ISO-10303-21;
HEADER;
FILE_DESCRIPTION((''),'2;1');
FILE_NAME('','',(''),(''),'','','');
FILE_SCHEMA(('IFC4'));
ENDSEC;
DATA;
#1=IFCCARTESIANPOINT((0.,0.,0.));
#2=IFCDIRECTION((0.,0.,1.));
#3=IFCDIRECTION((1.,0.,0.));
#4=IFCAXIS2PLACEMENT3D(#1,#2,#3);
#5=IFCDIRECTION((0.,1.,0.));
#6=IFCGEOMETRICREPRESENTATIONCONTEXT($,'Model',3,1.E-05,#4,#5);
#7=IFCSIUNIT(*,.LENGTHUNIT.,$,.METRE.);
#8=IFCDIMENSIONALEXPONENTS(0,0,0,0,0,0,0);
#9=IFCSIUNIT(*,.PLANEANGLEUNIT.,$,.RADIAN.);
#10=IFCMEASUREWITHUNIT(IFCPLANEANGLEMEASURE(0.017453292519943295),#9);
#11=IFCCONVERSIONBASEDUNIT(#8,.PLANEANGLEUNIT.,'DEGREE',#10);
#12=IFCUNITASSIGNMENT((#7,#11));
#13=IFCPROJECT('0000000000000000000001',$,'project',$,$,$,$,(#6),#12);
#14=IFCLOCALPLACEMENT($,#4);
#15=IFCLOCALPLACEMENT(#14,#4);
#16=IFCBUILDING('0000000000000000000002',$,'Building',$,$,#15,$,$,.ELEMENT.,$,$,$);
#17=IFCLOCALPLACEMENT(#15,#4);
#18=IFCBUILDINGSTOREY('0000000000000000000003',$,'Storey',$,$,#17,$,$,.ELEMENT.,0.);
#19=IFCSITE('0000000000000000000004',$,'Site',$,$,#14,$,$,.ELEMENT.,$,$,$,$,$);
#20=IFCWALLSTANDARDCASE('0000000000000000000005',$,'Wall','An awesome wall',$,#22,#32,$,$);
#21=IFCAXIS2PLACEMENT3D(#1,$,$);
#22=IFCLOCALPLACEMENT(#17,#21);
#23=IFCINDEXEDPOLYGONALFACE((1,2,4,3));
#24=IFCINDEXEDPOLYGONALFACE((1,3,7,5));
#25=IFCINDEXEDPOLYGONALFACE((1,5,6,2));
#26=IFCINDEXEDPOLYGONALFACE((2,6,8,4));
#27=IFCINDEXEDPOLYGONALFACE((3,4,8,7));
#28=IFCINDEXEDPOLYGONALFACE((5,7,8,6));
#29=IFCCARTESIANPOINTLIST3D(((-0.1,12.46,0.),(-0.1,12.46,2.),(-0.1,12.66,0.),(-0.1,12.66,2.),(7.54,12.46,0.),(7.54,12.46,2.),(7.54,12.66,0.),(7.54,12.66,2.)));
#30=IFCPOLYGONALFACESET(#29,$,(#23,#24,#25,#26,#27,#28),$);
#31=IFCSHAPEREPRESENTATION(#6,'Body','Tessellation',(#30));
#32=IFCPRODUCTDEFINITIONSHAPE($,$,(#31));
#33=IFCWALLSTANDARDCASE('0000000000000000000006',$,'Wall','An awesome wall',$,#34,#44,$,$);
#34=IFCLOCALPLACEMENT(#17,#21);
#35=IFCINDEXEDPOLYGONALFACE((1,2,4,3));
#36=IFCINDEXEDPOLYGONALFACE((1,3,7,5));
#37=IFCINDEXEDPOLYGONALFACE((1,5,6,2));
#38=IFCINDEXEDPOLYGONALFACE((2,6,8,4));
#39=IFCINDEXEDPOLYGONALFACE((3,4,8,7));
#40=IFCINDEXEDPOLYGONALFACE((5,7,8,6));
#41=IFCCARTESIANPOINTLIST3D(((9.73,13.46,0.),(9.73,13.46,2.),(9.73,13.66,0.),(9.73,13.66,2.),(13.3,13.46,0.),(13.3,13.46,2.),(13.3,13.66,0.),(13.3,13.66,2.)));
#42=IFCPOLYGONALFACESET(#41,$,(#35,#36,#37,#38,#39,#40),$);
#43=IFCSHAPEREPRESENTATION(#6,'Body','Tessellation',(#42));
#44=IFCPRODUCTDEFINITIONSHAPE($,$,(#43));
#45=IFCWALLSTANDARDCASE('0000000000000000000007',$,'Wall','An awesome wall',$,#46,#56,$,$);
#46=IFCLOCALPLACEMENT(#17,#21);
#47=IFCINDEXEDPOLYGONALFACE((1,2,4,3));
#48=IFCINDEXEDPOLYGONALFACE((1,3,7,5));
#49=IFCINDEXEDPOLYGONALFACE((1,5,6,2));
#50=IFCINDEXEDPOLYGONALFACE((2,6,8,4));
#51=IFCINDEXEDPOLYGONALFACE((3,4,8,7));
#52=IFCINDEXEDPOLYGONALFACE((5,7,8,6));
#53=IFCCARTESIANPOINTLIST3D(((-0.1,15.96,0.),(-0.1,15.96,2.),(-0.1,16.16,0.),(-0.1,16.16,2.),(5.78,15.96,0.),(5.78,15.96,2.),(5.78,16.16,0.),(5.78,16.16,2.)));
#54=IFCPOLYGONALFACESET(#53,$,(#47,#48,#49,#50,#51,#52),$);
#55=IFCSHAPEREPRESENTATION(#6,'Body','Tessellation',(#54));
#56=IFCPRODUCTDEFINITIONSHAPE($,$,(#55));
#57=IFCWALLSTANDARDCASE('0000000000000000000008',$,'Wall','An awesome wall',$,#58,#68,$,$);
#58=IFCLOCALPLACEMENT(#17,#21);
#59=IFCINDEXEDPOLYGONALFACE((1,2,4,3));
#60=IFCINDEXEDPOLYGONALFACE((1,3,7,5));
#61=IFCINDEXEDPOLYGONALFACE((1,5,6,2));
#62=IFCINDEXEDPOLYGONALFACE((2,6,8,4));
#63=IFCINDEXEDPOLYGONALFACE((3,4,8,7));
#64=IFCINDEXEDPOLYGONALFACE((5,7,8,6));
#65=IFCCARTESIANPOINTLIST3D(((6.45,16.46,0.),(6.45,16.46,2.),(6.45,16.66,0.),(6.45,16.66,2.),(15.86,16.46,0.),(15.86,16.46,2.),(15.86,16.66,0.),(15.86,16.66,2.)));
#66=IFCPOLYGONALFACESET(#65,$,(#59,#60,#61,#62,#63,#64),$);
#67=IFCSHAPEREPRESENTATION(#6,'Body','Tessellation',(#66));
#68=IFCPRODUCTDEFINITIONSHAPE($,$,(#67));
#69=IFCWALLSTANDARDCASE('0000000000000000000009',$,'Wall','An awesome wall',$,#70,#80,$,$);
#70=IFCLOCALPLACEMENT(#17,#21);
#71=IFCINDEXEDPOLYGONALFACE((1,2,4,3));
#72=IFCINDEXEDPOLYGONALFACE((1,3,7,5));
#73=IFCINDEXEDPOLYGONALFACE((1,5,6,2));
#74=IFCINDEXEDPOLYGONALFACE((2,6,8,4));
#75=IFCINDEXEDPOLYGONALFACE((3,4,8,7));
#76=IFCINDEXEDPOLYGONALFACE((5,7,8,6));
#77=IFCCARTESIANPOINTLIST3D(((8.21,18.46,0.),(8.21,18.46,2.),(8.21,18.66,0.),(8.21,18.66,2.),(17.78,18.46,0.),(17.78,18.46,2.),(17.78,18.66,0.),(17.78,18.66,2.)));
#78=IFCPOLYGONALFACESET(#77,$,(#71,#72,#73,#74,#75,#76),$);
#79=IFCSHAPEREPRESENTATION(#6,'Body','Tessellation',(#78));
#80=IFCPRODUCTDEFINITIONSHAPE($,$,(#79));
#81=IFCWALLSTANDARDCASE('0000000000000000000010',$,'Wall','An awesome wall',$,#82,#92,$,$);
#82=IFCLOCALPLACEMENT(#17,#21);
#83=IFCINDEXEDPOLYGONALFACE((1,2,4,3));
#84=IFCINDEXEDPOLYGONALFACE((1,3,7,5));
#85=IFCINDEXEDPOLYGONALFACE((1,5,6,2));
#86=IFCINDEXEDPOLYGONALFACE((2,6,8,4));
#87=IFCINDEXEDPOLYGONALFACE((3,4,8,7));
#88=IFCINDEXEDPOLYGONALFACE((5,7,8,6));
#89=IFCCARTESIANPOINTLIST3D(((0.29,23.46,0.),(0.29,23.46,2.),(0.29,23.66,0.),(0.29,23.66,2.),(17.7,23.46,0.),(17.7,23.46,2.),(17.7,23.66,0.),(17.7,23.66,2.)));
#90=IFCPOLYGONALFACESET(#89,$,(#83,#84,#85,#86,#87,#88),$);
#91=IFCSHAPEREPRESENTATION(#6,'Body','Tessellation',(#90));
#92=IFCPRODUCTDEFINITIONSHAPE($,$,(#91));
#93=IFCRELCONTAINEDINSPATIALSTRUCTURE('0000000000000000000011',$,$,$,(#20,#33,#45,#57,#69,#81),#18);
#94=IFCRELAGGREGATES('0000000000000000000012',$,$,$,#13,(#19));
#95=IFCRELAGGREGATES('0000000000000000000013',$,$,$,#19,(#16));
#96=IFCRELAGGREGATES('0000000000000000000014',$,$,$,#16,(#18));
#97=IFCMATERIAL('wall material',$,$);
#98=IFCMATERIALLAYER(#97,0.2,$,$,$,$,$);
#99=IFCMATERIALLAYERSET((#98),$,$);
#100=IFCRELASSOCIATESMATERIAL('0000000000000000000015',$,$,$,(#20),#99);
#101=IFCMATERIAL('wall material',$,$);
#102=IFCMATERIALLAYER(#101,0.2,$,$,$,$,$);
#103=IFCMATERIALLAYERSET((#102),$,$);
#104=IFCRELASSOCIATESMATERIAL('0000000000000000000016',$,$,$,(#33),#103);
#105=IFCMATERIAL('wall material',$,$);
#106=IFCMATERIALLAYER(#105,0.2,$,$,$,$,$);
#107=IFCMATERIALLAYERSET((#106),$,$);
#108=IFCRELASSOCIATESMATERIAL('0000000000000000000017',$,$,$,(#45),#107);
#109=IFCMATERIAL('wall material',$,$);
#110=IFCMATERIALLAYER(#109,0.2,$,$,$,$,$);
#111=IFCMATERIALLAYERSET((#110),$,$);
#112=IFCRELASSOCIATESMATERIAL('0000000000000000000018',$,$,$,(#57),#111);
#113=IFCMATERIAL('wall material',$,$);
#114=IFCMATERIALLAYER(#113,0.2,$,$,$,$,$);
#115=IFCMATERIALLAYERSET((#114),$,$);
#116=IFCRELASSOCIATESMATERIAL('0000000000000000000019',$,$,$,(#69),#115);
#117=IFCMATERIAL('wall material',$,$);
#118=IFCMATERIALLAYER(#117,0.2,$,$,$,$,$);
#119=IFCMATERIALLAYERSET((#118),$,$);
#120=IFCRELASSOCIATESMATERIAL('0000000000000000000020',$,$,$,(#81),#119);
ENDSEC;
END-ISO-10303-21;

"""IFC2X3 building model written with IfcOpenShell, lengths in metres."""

from ifc_helpers import new_model, entity, si_unit, converted_unit, direction, frame, origin_with_axes, place, context, project, spatial, polyline, outline, extrude, material, layer, layer_set, layer_usage, element, save


model = new_model("IFC2X3")

# Units and contexts
model_context = context("Model", 3, precision=1e-05, world=origin_with_axes(), true_north=direction((0.0, 1.0, 0.0)))
ifc_project = project(units=[si_unit("LENGTHUNIT", "METRE"), converted_unit("PLANEANGLEUNIT", "DEGREE", entity("IfcPlaneAngleMeasure", 0.017453292519943295), si_unit("PLANEANGLEUNIT", "RADIAN"), dimensions=[0, 0, 0, 0, 0, 0, 0])], contexts=[model_context])

# Site, building, storey
site_placement = place(None, origin_with_axes())
site = spatial("IfcSite", under=ifc_project, at=site_placement, Name="Site", CompositionType="ELEMENT")
building_placement = place(site_placement, origin_with_axes())
building = spatial("IfcBuilding", under=site, at=building_placement, Name="Building", CompositionType="ELEMENT")
storey_placement = place(building_placement, origin_with_axes())
storey = spatial("IfcBuildingStorey", under=building, at=storey_placement, Name="Storey", CompositionType="ELEMENT", Elevation=0.0)

# Walls
ifc_material_1 = material(Name="wall material")
ifc_layer_1 = layer(ifc_material_1, 0.2)
ifc_layer_set_1 = layer_set([ifc_layer_1])
ifc_layer_usage_1 = layer_usage(ifc_layer_set_1, "AXIS2", "POSITIVE", -0.1)
wall_1_placement = place(storey_placement, origin_with_axes())
element("IfcWallStandardCase", 1, at=wall_1_placement, inside=storey, material=ifc_layer_usage_1, Name="Wall", Description="An awesome wall", context=model_context, shape_type="SweptSolid", body=[
    extrude(outline(polyline([(0.0, -0.1, 0.0), (7.64, -0.1, 0.0), (7.64, 0.1, 0.0), (0.0, 0.1, 0.0), (0.0, -0.1, 0.0)])), frame((-0.1, 12.56, 0.0), z_axis=(0.0, 0.0, 1.0), x_axis=(1.0, 0.0, 0.0)), (0.0, 0.0, 1.0), 2.0),
])
ifc_material_2 = material(Name="wall material")
ifc_layer_2 = layer(ifc_material_2, 0.2)
ifc_layer_set_2 = layer_set([ifc_layer_2])
ifc_layer_usage_2 = layer_usage(ifc_layer_set_2, "AXIS2", "POSITIVE", -0.1)
wall_2_placement = place(storey_placement, origin_with_axes())
element("IfcWallStandardCase", 2, at=wall_2_placement, inside=storey, material=ifc_layer_usage_2, Name="Wall", Description="An awesome wall", context=model_context, shape_type="SweptSolid", body=[
    extrude(outline(polyline([(0.0, -0.1, 0.0), (3.57, -0.1, 0.0), (3.57, 0.1, 0.0), (0.0, 0.1, 0.0), (0.0, -0.1, 0.0)])), frame((9.73, 13.56, 0.0), z_axis=(0.0, 0.0, 1.0), x_axis=(1.0, 0.0, 0.0)), (0.0, 0.0, 1.0), 2.0),
])
ifc_material_3 = material(Name="wall material")
ifc_layer_3 = layer(ifc_material_3, 0.2)
ifc_layer_set_3 = layer_set([ifc_layer_3])
ifc_layer_usage_3 = layer_usage(ifc_layer_set_3, "AXIS2", "POSITIVE", -0.1)
wall_3_placement = place(storey_placement, origin_with_axes())
element("IfcWallStandardCase", 3, at=wall_3_placement, inside=storey, material=ifc_layer_usage_3, Name="Wall", Description="An awesome wall", context=model_context, shape_type="SweptSolid", body=[
    extrude(outline(polyline([(0.0, -0.1, 0.0), (5.88, -0.1, 0.0), (5.88, 0.1, 0.0), (0.0, 0.1, 0.0), (0.0, -0.1, 0.0)])), frame((-0.1, 16.06, 0.0), z_axis=(0.0, 0.0, 1.0), x_axis=(1.0, 0.0, 0.0)), (0.0, 0.0, 1.0), 2.0),
])
ifc_material_4 = material(Name="wall material")
ifc_layer_4 = layer(ifc_material_4, 0.2)
ifc_layer_set_4 = layer_set([ifc_layer_4])
ifc_layer_usage_4 = layer_usage(ifc_layer_set_4, "AXIS2", "POSITIVE", -0.1)
wall_4_placement = place(storey_placement, origin_with_axes())
element("IfcWallStandardCase", 4, at=wall_4_placement, inside=storey, material=ifc_layer_usage_4, Name="Wall", Description="An awesome wall", context=model_context, shape_type="SweptSolid", body=[
    extrude(outline(polyline([(0.0, -0.1, 0.0), (9.41, -0.1, 0.0), (9.41, 0.1, 0.0), (0.0, 0.1, 0.0), (0.0, -0.1, 0.0)])), frame((6.45, 16.56, 0.0), z_axis=(0.0, 0.0, 1.0), x_axis=(1.0, 0.0, 0.0)), (0.0, 0.0, 1.0), 2.0),
])
ifc_material_5 = material(Name="wall material")
ifc_layer_5 = layer(ifc_material_5, 0.2)
ifc_layer_set_5 = layer_set([ifc_layer_5])
ifc_layer_usage_5 = layer_usage(ifc_layer_set_5, "AXIS2", "POSITIVE", -0.1)
wall_5_placement = place(storey_placement, origin_with_axes())
element("IfcWallStandardCase", 5, at=wall_5_placement, inside=storey, material=ifc_layer_usage_5, Name="Wall", Description="An awesome wall", context=model_context, shape_type="SweptSolid", body=[
    extrude(outline(polyline([(0.0, -0.1, 0.0), (9.57, -0.1, 0.0), (9.57, 0.1, 0.0), (0.0, 0.1, 0.0), (0.0, -0.1, 0.0)])), frame((8.21, 18.56, 0.0), z_axis=(0.0, 0.0, 1.0), x_axis=(1.0, 0.0, 0.0)), (0.0, 0.0, 1.0), 2.0),
])
ifc_material_6 = material(Name="wall material")
ifc_layer_6 = layer(ifc_material_6, 0.2)
ifc_layer_set_6 = layer_set([ifc_layer_6])
ifc_layer_usage_6 = layer_usage(ifc_layer_set_6, "AXIS2", "POSITIVE", -0.1)
wall_6_placement = place(storey_placement, origin_with_axes())
element("IfcWallStandardCase", 6, at=wall_6_placement, inside=storey, material=ifc_layer_usage_6, Name="Wall", Description="An awesome wall", context=model_context, shape_type="SweptSolid", body=[
    extrude(outline(polyline([(0.0, -0.1, 0.0), (17.41, -0.1, 0.0), (17.41, 0.1, 0.0), (0.0, 0.1, 0.0), (0.0, -0.1, 0.0)])), frame((0.29, 23.56, 0.0), z_axis=(0.0, 0.0, 1.0), x_axis=(1.0, 0.0, 0.0)), (0.0, 0.0, 1.0), 2.0),
])

save(model, "model.ifc")
